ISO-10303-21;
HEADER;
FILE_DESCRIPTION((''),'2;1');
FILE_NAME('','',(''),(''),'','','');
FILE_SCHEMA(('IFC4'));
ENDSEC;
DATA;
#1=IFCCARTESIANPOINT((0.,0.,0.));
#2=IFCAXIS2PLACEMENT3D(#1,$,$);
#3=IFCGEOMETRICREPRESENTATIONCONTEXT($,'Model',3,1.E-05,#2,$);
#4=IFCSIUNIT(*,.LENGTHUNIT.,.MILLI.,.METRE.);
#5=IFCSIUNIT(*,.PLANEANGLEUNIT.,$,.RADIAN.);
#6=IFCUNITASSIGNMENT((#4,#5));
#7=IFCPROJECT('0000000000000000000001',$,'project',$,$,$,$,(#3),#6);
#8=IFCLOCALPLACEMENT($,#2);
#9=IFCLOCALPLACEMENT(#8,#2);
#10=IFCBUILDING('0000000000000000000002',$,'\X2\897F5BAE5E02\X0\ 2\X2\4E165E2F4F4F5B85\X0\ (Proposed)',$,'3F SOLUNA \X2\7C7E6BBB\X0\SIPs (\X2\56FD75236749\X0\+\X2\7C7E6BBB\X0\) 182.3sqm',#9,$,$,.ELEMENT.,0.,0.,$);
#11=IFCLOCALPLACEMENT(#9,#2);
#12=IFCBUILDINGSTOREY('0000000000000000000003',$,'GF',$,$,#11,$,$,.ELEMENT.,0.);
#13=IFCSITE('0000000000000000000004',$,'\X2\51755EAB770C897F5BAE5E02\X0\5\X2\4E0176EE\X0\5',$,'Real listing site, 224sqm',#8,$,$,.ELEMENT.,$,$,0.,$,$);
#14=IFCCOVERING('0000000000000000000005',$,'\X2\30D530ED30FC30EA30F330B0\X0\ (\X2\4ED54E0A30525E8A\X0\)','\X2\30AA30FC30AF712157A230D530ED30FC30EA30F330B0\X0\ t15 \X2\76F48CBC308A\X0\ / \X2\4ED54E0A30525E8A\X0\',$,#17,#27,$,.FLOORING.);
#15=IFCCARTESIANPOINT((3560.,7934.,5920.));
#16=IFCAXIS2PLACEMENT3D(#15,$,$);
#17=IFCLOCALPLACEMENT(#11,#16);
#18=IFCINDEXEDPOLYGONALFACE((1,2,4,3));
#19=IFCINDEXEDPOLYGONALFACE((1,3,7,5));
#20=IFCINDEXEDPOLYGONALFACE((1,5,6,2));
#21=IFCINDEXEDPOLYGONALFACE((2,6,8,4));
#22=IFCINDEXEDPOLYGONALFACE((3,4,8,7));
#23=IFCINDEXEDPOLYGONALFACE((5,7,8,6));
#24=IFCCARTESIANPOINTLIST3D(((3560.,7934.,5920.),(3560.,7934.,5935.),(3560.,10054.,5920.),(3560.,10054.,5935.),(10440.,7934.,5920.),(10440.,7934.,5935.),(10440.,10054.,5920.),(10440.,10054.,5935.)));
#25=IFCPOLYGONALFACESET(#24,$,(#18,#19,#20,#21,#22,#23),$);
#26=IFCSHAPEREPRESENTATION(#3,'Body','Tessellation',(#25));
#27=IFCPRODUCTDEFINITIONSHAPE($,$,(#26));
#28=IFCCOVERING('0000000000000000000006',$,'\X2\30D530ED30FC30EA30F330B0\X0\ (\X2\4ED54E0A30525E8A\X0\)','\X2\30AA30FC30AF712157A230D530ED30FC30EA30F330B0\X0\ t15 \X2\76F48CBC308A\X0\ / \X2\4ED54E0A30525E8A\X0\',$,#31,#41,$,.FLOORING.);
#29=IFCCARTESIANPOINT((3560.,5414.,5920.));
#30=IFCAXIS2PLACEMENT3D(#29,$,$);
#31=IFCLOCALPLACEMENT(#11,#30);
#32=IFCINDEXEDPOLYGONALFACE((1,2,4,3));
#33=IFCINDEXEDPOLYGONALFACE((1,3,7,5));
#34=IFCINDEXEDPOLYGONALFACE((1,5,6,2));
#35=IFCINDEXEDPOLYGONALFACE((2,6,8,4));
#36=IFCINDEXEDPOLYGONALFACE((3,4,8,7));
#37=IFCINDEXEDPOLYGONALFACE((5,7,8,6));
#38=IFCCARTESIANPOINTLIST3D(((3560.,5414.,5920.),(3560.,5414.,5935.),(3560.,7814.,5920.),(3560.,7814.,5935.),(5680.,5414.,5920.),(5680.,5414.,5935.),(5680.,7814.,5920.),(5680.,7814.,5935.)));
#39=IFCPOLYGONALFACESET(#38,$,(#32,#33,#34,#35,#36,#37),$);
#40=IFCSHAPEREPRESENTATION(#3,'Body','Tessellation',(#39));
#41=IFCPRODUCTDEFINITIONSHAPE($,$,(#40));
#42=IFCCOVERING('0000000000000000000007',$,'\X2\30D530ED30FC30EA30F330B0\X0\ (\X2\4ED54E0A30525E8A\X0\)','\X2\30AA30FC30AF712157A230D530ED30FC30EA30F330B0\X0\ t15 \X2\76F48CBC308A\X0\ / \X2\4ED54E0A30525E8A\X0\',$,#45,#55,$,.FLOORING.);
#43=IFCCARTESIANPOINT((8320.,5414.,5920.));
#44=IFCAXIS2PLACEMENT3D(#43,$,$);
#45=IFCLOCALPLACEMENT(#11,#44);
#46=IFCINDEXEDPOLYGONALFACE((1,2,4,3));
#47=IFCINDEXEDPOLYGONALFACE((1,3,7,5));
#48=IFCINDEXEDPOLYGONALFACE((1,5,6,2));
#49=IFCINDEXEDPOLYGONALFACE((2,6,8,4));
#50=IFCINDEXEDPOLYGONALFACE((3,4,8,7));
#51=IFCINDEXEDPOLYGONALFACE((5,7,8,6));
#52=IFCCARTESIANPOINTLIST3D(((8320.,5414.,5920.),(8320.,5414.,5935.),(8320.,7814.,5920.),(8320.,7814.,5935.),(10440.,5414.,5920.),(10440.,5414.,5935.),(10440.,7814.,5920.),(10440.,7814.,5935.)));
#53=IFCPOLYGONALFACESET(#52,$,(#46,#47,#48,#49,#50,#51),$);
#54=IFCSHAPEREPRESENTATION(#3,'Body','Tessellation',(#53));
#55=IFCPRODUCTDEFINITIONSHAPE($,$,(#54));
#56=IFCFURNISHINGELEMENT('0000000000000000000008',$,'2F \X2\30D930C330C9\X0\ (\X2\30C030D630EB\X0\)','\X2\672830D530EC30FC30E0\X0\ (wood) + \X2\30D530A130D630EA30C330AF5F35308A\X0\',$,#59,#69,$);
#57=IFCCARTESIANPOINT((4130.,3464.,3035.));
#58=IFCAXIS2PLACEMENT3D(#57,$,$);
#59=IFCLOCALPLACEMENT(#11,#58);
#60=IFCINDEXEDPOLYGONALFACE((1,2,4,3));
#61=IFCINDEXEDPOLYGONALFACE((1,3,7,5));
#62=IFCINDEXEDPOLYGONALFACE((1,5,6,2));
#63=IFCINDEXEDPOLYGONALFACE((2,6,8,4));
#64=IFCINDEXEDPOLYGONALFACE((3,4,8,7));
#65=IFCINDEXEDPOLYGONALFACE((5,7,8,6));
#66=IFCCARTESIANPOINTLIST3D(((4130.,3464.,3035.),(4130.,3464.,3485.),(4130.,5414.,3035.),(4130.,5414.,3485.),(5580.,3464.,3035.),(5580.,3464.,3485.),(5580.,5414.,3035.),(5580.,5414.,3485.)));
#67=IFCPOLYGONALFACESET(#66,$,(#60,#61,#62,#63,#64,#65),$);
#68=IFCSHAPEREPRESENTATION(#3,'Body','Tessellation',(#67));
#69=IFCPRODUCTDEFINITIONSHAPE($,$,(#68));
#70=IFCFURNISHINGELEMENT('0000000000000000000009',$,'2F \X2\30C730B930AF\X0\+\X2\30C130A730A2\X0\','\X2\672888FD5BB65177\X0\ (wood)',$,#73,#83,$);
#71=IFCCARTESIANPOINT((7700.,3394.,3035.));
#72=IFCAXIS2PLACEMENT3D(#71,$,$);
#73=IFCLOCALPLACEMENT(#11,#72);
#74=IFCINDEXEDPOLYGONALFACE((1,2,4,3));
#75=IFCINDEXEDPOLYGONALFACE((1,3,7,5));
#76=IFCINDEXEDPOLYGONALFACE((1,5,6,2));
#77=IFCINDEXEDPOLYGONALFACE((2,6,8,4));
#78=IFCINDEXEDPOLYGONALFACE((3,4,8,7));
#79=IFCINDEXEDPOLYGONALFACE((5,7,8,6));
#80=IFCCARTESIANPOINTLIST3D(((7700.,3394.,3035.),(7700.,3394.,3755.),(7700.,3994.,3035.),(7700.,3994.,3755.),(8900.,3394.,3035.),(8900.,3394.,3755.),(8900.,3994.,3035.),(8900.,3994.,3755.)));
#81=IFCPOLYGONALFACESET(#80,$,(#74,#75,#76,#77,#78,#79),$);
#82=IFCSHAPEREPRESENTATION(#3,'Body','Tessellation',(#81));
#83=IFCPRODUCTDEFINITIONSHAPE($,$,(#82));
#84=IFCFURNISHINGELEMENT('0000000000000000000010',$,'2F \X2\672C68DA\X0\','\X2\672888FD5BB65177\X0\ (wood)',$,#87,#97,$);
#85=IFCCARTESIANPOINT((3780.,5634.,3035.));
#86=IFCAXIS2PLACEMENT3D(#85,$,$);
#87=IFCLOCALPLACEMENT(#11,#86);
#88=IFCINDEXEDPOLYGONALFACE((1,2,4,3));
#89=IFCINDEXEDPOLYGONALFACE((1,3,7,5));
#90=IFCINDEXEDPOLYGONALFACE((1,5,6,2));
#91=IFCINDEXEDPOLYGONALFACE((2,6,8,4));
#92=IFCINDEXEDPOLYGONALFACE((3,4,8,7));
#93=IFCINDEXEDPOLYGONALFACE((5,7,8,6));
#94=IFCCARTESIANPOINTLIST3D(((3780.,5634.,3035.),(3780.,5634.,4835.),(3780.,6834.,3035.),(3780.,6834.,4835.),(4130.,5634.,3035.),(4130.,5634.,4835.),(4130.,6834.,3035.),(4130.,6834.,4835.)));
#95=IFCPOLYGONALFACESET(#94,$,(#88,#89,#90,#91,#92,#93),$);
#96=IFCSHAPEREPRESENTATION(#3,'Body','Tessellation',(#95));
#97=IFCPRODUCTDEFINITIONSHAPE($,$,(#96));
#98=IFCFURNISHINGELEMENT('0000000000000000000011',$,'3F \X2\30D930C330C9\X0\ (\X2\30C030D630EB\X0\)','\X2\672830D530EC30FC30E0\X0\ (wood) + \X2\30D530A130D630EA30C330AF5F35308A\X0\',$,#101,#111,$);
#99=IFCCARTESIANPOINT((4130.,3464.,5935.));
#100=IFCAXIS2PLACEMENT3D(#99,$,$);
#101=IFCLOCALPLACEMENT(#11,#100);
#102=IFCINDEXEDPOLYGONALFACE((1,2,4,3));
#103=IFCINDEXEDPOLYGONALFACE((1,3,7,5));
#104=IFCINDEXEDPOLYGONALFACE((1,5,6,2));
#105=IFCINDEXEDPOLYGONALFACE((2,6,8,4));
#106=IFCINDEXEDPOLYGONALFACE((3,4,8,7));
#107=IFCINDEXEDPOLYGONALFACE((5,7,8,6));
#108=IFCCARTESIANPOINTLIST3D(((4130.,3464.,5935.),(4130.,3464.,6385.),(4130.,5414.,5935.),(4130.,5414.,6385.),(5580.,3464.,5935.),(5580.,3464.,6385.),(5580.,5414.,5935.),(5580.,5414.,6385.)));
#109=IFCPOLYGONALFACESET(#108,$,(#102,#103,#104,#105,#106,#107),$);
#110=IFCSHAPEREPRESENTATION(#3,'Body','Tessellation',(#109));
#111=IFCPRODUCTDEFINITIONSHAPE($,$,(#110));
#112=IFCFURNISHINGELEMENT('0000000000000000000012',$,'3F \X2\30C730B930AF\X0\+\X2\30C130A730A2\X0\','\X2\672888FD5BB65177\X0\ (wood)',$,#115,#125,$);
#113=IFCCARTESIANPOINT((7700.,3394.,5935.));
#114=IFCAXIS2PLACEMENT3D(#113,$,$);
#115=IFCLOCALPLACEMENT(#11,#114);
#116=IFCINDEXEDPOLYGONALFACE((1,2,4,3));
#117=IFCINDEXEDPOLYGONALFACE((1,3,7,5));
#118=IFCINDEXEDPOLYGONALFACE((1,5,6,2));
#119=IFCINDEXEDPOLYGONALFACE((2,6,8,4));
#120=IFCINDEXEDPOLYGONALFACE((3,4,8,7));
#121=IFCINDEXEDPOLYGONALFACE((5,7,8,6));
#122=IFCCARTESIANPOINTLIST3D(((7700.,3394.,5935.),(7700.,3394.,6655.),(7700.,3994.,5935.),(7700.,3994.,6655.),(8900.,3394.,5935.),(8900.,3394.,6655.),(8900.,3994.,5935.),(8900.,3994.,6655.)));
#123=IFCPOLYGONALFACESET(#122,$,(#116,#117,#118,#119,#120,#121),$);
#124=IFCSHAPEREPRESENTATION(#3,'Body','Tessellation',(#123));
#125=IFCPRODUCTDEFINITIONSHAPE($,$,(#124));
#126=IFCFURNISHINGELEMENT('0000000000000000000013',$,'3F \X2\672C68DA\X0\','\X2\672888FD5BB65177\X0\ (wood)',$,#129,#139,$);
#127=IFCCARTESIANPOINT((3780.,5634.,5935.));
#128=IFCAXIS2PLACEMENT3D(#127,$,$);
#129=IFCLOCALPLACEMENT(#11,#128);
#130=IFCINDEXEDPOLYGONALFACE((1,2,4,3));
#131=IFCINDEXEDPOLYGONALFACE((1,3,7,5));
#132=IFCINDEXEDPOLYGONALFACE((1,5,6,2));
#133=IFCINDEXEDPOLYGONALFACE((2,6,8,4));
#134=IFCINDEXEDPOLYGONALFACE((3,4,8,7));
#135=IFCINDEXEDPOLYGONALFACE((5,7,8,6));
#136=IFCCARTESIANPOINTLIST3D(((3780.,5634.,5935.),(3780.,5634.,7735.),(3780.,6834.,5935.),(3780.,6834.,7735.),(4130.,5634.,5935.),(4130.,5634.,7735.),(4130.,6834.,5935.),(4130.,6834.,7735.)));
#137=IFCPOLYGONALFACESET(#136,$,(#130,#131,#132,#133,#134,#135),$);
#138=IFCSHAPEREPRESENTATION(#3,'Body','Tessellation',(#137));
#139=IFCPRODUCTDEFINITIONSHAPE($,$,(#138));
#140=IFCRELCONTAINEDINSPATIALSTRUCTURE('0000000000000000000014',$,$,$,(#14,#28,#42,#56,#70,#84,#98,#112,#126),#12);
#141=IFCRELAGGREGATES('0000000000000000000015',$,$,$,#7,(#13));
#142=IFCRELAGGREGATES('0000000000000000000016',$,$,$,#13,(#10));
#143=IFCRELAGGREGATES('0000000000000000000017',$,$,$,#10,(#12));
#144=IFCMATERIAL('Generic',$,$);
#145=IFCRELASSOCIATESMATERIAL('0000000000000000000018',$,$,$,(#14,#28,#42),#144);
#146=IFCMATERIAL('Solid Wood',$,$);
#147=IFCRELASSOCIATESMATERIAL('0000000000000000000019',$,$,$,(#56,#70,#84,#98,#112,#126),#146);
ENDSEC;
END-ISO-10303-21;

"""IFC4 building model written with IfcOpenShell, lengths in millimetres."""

from ifc_helpers import new_model, si_unit, frame, frame_2d, origin, place, context, project, spatial, rectangle, extrude, material, element, save


model = new_model("IFC4")

# Units and contexts
model_context = context("Model", 3, precision=1e-05, world=origin())
ifc_project = project(units=[si_unit("LENGTHUNIT", "METRE", prefix="MILLI"), si_unit("PLANEANGLEUNIT", "RADIAN")], contexts=[model_context])

# Site, building, storey
site_placement = place(None, origin())
site = spatial("IfcSite", under=ifc_project, at=site_placement, Name="兵庫県西宮市5丁目5", ObjectType="Real listing site, 224sqm", CompositionType="ELEMENT", RefElevation=0.0)
building_placement = place(site_placement, origin())
building = spatial("IfcBuilding", under=site, at=building_placement, Name="西宮市 2世帯住宅 (Proposed)", ObjectType="3F SOLUNA 籾殻SIPs (国産杉+籾殻) 182.3sqm", CompositionType="ELEMENT", ElevationOfRefHeight=0.0, ElevationOfTerrain=0.0)
storey_placement = place(building_placement, origin())
storey = spatial("IfcBuildingStorey", under=building, at=storey_placement, Name="GF", CompositionType="ELEMENT", Elevation=0.0)

# Shared definitions
ifc_material_1 = material(Name="Solid Wood")

# Shared definitions
ifc_material_2 = material(Name="Generic")

# Coverings
covering_1_placement = place(storey_placement, frame((3560.0, 7934.0, 5920.0)))
element("IfcCovering", 1, at=covering_1_placement, inside=storey, material=ifc_material_2, Name="フローリング (仕上げ床)", Description="オーク無垢フローリング t15 直貼り / 仕上げ床", PredefinedType="FLOORING", context=model_context, shape_type="SweptSolid", body=[
    extrude(rectangle(XDim=6880.0, YDim=2120.0, at=frame_2d((3440.0, 1060.0))), frame((3560.0, 7934.0, 5920.0)), (0.0, 0.0, 1.0), 15.0),
])
covering_2_placement = place(storey_placement, frame((3560.0, 5414.0, 5920.0)))
element("IfcCovering", 2, at=covering_2_placement, inside=storey, material=ifc_material_2, Name="フローリング (仕上げ床)", Description="オーク無垢フローリング t15 直貼り / 仕上げ床", PredefinedType="FLOORING", context=model_context, shape_type="SweptSolid", body=[
    extrude(rectangle(XDim=2120.0, YDim=2400.0, at=frame_2d((1060.0, 1200.0))), frame((3560.0, 5414.0, 5920.0)), (0.0, 0.0, 1.0), 15.0),
])
covering_3_placement = place(storey_placement, frame((8320.0, 5414.0, 5920.0)))
element("IfcCovering", 3, at=covering_3_placement, inside=storey, material=ifc_material_2, Name="フローリング (仕上げ床)", Description="オーク無垢フローリング t15 直貼り / 仕上げ床", PredefinedType="FLOORING", context=model_context, shape_type="SweptSolid", body=[
    extrude(rectangle(XDim=2120.0, YDim=2400.0, at=frame_2d((1060.0, 1200.0))), frame((8320.0, 5414.0, 5920.0)), (0.0, 0.0, 1.0), 15.0),
])

# Furnishing elements
furnishing_1_placement = place(storey_placement, frame((4130.0, 3464.0, 3035.0)))
element("IfcFurnishingElement", 4, at=furnishing_1_placement, inside=storey, material=ifc_material_1, Name="2F ベッド (ダブル)", Description="木フレーム (wood) + ファブリック張り", context=model_context, shape_type="SweptSolid", body=[
    extrude(rectangle(XDim=1450.0, YDim=1950.0, at=frame_2d((725.0, 975.0))), frame((4130.0, 3464.0, 3035.0)), (0.0, 0.0, 1.0), 450.0),
])
furnishing_2_placement = place(storey_placement, frame((7700.0, 3394.0, 3035.0)))
element("IfcFurnishingElement", 5, at=furnishing_2_placement, inside=storey, material=ifc_material_1, Name="2F デスク+チェア", Description="木製家具 (wood)", context=model_context, shape_type="SweptSolid", body=[
    extrude(rectangle(XDim=1200.0, YDim=600.0, at=frame_2d((600.0, 300.0))), frame((7700.0, 3394.0, 3035.0)), (0.0, 0.0, 1.0), 720.0),
])
furnishing_3_placement = place(storey_placement, frame((3780.0, 5634.0, 3035.0)))
element("IfcFurnishingElement", 6, at=furnishing_3_placement, inside=storey, material=ifc_material_1, Name="2F 本棚", Description="木製家具 (wood)", context=model_context, shape_type="SweptSolid", body=[
    extrude(rectangle(XDim=350.0, YDim=1200.0, at=frame_2d((175.0, 600.0))), frame((3780.0, 5634.0, 3035.0)), (0.0, 0.0, 1.0), 1800.0),
])
furnishing_4_placement = place(storey_placement, frame((4130.0, 3464.0, 5935.0)))
element("IfcFurnishingElement", 7, at=furnishing_4_placement, inside=storey, material=ifc_material_1, Name="3F ベッド (ダブル)", Description="木フレーム (wood) + ファブリック張り", context=model_context, shape_type="SweptSolid", body=[
    extrude(rectangle(XDim=1450.0, YDim=1950.0, at=frame_2d((725.0, 975.0))), frame((4130.0, 3464.0, 5935.0)), (0.0, 0.0, 1.0), 450.0),
])
furnishing_5_placement = place(storey_placement, frame((7700.0, 3394.0, 5935.0)))
element("IfcFurnishingElement", 8, at=furnishing_5_placement, inside=storey, material=ifc_material_1, Name="3F デスク+チェア", Description="木製家具 (wood)", context=model_context, shape_type="SweptSolid", body=[
    extrude(rectangle(XDim=1200.0, YDim=600.0, at=frame_2d((600.0, 300.0))), frame((7700.0, 3394.0, 5935.0)), (0.0, 0.0, 1.0), 720.0),
])
furnishing_6_placement = place(storey_placement, frame((3780.0, 5634.0, 5935.0)))
element("IfcFurnishingElement", 9, at=furnishing_6_placement, inside=storey, material=ifc_material_1, Name="3F 本棚", Description="木製家具 (wood)", context=model_context, shape_type="SweptSolid", body=[
    extrude(rectangle(XDim=350.0, YDim=1200.0, at=frame_2d((175.0, 600.0))), frame((3780.0, 5634.0, 5935.0)), (0.0, 0.0, 1.0), 1800.0),
])

save(model, "model.ifc")
